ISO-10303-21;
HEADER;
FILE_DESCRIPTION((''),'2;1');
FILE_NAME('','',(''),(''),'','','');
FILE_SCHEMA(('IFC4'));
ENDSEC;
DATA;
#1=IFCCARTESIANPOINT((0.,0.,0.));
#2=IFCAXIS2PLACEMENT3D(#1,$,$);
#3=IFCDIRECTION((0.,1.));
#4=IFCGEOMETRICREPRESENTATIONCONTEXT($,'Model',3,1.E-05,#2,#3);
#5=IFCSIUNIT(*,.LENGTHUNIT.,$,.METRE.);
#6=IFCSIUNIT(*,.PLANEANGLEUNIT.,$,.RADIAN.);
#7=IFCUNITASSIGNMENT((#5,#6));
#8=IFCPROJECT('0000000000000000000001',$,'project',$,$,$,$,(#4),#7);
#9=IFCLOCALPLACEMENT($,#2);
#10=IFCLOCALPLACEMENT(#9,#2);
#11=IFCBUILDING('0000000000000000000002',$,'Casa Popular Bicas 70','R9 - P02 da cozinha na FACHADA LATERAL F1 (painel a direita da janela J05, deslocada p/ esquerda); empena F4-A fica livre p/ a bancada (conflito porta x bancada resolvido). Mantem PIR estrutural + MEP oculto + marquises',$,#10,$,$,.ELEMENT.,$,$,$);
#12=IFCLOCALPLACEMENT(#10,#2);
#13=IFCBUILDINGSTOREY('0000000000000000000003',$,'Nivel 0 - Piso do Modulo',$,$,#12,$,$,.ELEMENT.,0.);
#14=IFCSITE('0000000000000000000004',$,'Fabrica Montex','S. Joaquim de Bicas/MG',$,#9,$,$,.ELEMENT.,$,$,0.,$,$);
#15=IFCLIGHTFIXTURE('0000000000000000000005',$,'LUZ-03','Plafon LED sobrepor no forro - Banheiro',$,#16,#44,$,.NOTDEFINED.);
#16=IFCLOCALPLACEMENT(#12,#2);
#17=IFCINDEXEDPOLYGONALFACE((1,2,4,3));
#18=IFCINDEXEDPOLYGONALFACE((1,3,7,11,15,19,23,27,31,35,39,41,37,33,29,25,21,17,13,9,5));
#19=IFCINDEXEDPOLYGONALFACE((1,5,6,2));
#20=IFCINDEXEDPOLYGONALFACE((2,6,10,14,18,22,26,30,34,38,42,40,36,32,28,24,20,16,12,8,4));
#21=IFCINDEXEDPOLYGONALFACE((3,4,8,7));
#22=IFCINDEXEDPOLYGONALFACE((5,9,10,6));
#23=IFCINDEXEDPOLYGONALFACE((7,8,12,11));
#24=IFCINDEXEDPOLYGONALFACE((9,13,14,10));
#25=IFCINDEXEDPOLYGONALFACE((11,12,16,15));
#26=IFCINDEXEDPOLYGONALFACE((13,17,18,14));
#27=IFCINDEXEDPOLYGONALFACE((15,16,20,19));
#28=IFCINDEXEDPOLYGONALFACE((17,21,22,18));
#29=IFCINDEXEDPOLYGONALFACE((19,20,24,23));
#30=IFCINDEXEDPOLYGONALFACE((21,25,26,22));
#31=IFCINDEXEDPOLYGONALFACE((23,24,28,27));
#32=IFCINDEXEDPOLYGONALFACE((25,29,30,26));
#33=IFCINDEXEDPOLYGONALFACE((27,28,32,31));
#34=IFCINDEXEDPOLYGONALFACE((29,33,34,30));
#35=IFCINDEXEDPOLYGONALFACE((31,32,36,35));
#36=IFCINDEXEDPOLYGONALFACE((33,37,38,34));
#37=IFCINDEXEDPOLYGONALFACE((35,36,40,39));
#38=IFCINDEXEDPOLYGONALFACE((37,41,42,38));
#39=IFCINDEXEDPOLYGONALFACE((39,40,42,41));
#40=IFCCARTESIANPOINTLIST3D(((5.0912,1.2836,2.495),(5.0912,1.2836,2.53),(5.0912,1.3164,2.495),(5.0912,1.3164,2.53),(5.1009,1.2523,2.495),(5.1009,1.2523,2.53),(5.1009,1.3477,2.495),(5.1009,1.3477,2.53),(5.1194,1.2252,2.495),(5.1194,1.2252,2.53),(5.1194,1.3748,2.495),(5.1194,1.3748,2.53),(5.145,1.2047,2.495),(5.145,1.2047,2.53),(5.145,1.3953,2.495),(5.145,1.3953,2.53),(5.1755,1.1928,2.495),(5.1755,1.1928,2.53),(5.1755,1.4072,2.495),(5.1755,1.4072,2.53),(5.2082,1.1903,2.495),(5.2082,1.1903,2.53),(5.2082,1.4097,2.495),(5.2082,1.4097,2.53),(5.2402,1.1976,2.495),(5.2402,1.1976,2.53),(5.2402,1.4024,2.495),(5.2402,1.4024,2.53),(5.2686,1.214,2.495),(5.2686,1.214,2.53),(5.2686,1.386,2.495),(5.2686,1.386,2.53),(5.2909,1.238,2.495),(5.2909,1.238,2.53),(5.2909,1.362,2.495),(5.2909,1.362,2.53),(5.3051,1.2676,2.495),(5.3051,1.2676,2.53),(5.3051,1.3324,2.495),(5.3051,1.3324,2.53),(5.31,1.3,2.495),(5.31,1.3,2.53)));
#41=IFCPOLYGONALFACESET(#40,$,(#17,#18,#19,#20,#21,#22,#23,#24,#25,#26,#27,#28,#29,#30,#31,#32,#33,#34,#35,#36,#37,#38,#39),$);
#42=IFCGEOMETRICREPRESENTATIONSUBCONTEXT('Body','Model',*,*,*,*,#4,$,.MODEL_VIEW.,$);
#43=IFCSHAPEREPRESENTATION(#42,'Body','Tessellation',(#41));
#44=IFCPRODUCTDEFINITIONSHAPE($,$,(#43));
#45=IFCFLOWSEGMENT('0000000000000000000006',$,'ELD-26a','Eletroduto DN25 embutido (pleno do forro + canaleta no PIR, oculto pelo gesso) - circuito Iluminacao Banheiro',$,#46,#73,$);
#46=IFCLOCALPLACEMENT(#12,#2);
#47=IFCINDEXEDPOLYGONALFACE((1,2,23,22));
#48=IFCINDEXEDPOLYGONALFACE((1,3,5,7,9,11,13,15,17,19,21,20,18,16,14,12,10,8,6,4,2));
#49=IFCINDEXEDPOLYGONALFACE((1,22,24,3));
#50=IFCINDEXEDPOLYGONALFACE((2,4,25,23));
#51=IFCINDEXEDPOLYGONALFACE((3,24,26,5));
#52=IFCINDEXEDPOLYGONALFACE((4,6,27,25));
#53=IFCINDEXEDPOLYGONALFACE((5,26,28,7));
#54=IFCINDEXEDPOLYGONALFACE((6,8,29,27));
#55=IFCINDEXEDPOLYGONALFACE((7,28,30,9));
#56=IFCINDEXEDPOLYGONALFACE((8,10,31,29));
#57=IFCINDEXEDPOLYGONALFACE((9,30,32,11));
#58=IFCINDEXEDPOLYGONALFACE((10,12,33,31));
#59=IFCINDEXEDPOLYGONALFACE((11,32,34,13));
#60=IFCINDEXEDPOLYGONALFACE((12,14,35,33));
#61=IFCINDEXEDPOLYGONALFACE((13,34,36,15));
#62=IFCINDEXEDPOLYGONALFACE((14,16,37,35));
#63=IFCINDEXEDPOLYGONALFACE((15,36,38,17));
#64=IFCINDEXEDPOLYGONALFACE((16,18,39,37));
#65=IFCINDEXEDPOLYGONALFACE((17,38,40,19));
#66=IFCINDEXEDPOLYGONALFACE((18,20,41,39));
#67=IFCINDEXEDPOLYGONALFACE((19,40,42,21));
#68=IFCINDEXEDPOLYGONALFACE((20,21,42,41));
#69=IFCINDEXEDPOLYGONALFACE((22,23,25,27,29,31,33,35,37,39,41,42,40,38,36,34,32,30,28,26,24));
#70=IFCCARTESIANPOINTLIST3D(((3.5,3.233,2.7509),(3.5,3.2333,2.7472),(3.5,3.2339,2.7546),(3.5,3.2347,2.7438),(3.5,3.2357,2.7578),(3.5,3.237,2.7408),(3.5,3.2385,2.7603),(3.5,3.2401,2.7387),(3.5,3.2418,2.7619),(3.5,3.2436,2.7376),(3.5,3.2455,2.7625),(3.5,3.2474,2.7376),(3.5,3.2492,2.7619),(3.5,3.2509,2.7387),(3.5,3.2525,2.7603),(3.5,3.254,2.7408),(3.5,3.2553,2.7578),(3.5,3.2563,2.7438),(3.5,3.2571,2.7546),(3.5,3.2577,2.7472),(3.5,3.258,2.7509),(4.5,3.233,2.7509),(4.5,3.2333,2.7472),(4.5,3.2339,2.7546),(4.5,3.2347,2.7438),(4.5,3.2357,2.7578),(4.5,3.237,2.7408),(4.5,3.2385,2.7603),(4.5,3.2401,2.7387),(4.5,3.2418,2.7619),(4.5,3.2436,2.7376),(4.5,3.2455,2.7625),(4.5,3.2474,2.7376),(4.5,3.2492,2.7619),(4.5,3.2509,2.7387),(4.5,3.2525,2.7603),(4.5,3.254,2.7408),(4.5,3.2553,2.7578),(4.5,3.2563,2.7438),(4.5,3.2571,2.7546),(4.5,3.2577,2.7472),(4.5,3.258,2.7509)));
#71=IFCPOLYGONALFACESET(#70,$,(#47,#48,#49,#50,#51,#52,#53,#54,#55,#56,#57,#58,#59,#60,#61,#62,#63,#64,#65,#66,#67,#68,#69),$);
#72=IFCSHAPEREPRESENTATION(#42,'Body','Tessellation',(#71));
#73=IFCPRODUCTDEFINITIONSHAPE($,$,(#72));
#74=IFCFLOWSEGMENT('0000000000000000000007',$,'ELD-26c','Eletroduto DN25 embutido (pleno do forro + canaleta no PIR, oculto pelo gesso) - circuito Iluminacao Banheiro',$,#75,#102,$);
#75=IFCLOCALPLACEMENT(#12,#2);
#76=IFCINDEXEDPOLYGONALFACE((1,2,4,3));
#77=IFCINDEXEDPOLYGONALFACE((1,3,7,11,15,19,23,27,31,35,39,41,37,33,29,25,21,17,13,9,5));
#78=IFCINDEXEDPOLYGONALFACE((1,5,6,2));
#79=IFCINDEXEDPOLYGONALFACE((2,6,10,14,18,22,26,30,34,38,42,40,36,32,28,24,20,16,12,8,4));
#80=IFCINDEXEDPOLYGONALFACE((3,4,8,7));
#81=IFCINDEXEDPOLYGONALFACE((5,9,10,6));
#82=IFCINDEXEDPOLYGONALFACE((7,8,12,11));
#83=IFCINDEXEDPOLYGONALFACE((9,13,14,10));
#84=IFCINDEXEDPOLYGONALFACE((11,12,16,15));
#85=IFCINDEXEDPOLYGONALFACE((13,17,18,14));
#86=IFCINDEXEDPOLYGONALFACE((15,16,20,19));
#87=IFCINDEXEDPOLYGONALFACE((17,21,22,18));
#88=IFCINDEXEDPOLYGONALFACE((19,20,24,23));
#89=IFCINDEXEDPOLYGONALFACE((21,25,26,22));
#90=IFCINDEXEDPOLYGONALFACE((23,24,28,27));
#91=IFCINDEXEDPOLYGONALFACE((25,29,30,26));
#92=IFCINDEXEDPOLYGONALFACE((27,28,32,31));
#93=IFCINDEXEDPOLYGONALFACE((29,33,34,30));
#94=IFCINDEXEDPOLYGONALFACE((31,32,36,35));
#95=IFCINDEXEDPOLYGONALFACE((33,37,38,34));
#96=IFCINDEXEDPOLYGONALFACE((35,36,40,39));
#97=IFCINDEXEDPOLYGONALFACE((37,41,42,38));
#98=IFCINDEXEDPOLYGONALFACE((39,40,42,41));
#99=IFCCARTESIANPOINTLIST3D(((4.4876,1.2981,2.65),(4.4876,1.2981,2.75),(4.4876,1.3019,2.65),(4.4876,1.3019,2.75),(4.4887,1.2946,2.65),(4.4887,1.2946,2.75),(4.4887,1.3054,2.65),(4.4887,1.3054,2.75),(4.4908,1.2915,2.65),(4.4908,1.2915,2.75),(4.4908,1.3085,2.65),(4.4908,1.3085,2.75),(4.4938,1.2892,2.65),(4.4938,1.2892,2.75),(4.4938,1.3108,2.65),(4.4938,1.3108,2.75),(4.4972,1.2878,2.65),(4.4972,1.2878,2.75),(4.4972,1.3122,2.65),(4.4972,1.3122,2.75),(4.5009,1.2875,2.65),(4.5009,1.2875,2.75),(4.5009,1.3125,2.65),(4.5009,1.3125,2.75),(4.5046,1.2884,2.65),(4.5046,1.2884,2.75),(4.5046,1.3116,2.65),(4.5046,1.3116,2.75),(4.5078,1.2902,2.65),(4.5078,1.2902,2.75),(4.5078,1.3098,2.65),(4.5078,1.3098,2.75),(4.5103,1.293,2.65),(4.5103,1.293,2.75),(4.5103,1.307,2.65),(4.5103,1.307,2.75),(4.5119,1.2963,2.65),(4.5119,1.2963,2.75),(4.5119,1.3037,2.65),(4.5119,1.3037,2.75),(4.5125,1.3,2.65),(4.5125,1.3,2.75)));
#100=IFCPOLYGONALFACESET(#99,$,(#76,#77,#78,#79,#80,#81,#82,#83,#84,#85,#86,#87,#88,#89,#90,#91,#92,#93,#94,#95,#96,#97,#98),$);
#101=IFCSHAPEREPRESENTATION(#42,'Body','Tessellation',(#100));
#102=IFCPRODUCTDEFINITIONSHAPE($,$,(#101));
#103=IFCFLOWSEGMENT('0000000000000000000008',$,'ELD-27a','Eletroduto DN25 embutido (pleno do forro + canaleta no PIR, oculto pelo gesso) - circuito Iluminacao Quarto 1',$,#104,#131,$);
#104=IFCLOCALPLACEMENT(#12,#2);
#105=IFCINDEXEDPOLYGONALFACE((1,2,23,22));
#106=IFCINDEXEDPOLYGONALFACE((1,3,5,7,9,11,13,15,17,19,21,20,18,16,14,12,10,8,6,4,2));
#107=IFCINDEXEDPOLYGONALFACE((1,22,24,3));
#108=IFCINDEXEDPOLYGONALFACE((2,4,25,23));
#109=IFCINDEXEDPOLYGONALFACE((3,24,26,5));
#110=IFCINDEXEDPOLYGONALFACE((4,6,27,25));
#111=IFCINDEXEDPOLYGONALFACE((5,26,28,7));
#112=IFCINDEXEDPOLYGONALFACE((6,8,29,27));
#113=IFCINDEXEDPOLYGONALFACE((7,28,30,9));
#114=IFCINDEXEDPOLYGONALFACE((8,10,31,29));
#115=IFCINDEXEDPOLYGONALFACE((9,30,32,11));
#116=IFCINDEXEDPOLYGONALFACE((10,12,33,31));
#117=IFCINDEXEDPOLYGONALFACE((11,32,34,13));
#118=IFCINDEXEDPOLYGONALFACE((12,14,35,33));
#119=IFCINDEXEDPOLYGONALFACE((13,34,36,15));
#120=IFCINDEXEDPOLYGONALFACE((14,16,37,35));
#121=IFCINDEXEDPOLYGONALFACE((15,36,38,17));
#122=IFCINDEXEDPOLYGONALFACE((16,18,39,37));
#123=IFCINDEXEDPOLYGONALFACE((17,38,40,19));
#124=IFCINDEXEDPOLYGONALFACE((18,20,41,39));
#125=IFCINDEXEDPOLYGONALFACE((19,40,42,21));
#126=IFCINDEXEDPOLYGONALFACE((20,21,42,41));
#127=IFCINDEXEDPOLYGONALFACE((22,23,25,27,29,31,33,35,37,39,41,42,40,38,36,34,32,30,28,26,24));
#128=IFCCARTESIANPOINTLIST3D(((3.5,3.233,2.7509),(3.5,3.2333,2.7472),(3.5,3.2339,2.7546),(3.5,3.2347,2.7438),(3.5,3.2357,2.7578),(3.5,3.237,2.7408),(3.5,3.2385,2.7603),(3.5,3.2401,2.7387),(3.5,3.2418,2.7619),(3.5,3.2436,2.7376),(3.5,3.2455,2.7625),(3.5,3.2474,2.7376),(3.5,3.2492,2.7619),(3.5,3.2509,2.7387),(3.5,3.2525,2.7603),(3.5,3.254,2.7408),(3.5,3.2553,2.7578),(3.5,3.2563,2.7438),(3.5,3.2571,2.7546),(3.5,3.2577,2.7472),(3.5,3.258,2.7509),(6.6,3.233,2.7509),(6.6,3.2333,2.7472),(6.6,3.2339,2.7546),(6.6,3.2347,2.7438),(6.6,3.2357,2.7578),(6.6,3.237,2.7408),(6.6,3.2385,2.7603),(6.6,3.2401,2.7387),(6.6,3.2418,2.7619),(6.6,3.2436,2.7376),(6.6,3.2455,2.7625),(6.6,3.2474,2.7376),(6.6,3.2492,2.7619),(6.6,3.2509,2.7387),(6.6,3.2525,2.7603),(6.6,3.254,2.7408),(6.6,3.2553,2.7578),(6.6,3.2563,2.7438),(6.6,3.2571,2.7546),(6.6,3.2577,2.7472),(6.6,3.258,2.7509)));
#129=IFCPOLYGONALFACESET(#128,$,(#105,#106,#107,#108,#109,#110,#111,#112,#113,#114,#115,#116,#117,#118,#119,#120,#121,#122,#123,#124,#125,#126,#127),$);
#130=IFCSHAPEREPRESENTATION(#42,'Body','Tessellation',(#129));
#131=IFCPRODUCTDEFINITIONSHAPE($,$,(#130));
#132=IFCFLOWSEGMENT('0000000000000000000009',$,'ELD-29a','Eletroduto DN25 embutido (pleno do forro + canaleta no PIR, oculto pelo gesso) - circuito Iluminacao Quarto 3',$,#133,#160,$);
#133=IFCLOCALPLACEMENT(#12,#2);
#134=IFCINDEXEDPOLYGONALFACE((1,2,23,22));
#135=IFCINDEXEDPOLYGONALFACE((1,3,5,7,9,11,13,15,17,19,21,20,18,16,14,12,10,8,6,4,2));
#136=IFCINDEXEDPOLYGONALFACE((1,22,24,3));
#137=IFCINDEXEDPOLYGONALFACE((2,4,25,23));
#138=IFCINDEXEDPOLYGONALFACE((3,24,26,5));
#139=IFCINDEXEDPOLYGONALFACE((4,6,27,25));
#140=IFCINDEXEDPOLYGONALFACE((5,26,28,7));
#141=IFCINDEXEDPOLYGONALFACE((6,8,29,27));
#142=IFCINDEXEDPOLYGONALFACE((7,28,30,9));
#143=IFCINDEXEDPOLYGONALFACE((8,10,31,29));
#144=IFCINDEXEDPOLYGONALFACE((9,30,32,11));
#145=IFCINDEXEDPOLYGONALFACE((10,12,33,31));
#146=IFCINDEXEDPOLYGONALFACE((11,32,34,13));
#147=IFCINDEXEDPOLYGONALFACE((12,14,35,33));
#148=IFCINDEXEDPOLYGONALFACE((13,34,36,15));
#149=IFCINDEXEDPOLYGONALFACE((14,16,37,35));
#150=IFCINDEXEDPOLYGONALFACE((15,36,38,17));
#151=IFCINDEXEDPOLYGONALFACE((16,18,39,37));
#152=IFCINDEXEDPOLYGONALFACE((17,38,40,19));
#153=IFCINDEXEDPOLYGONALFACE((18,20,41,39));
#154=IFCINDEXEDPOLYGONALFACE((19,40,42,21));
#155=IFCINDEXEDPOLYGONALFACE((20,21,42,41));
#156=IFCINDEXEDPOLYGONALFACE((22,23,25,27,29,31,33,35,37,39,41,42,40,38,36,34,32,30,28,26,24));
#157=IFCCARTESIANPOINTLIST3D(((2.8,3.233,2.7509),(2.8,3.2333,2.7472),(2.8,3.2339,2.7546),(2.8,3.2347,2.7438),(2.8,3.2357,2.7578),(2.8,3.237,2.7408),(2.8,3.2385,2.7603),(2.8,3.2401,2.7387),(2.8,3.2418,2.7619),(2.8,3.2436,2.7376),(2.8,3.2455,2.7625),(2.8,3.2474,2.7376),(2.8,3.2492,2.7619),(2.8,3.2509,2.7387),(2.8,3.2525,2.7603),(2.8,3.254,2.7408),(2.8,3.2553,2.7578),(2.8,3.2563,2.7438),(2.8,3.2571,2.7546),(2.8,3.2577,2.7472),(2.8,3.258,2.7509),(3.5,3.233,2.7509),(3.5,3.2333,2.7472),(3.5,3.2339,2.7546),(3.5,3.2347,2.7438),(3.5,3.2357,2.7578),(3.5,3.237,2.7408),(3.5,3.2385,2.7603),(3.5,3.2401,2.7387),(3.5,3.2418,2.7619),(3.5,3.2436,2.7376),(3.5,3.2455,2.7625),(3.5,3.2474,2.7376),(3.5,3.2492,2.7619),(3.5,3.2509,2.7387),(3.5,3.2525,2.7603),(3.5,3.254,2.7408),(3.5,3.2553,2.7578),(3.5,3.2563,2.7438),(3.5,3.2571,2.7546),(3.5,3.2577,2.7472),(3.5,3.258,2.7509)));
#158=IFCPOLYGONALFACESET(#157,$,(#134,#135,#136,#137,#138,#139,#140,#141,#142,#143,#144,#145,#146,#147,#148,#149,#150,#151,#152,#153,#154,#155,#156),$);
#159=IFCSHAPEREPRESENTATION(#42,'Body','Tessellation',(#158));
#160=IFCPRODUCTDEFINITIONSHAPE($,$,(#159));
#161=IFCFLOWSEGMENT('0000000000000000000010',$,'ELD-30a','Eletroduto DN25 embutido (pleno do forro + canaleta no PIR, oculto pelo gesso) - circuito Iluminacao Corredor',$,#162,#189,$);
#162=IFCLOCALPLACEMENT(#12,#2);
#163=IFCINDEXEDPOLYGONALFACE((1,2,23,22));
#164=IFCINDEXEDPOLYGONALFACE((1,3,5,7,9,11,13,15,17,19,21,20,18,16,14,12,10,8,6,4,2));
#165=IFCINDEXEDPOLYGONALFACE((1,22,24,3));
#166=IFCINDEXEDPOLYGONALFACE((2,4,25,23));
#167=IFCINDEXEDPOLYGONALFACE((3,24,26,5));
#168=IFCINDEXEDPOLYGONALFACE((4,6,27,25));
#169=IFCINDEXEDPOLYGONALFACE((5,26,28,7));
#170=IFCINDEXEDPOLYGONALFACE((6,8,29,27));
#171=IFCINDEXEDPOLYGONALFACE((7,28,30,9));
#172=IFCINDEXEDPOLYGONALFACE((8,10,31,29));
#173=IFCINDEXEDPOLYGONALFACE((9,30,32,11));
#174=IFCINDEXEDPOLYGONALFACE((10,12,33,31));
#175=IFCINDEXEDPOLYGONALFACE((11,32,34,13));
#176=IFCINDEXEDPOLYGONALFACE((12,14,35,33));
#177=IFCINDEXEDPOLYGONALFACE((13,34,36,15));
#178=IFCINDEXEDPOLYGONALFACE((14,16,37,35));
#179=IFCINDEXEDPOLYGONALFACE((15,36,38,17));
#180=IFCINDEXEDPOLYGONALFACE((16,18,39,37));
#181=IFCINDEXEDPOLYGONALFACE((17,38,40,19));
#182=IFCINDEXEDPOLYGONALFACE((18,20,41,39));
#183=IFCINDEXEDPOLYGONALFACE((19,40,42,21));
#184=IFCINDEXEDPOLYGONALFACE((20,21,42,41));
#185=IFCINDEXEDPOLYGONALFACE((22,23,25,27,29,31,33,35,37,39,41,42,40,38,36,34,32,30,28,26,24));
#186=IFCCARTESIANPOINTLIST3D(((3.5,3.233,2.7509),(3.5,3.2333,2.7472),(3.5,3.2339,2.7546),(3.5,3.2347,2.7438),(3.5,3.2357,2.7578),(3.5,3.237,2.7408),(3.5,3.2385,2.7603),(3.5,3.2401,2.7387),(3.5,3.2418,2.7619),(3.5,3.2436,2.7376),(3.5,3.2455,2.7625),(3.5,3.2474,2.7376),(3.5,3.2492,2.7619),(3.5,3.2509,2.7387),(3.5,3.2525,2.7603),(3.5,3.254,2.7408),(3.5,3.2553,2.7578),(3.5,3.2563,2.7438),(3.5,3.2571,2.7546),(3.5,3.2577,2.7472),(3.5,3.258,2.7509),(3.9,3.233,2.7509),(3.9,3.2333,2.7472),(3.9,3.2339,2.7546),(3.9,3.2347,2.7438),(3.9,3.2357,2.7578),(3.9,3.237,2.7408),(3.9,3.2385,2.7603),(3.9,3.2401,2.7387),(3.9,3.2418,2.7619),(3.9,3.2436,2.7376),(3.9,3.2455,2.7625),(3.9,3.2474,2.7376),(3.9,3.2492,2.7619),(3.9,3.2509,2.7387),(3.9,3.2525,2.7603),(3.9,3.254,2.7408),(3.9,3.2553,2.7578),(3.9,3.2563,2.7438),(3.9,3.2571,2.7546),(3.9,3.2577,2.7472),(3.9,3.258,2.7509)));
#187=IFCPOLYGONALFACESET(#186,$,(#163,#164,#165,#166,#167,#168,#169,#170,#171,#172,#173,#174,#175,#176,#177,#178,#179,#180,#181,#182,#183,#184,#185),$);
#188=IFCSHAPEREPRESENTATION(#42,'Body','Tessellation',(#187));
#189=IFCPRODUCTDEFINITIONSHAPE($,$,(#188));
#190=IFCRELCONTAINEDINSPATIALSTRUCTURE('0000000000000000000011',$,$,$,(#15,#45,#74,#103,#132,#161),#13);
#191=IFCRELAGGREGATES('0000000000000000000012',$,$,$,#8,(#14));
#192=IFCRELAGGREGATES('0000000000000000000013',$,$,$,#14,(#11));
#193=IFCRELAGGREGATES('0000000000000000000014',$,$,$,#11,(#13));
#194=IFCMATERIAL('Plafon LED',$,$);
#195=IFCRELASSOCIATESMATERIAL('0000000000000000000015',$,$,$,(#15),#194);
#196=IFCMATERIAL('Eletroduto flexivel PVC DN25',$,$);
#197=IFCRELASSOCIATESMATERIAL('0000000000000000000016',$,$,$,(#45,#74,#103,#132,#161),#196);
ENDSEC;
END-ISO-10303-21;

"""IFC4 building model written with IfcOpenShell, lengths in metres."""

from ifc_helpers import new_model, si_unit, direction, frame, origin, origin_2d, place, context, subcontext, project, spatial, circle, extrude, material, element, save


model = new_model("IFC4")

# Units and contexts
model_context = context("Model", 3, precision=1e-05, world=origin(), true_north=direction((0.0, 1.0)))
body_context = subcontext(model_context, "Body", "Model", "MODEL_VIEW")
ifc_project = project(units=[si_unit("LENGTHUNIT", "METRE"), si_unit("PLANEANGLEUNIT", "RADIAN")], contexts=[model_context])

# Site, building, storey
site_placement = place(None, origin())
site = spatial("IfcSite", under=ifc_project, at=site_placement, Name="Fabrica Montex", Description="S. Joaquim de Bicas/MG", CompositionType="ELEMENT", RefElevation=0.0)
building_placement = place(site_placement, origin())
building = spatial("IfcBuilding", under=site, at=building_placement, Name="Casa Popular Bicas 70", Description="R9 - P02 da cozinha na FACHADA LATERAL F1 (painel a direita da janela J05, deslocada p/ esquerda); empena F4-A fica livre p/ a bancada (conflito porta x bancada resolvido). Mantem PIR estrutural + MEP oculto + marquises", CompositionType="ELEMENT")
storey_placement = place(building_placement, origin())
storey = spatial("IfcBuildingStorey", under=building, at=storey_placement, Name="Nivel 0 - Piso do Modulo", CompositionType="ELEMENT", Elevation=0.0)

# Shared definitions
ifc_material_1 = material(Name="Eletroduto flexivel PVC DN25")

# Light fixture
ifc_material_2 = material(Name="Plafon LED")
light_fixture_placement = place(storey_placement, frame((5.2, 1.3, 2.495)))
element("IfcLightFixture", 1, at=light_fixture_placement, inside=storey, material=ifc_material_2, Name="LUZ-03", Description="Plafon LED sobrepor no forro - Banheiro", PredefinedType="NOTDEFINED", context=body_context, shape_type="SweptSolid", body=[
    extrude(circle(Radius=0.11, at=origin_2d()), origin(), (0.0, 0.0, 1.0), 0.035),
])

# Flow segments
flow_segment_1_placement = place(storey_placement, frame((3.5, 3.2455, 2.75), z_axis=(1.0, 0.0, 0.0), x_axis=(0.0, 0.0, 1.0)))
element("IfcFlowSegment", 2, at=flow_segment_1_placement, inside=storey, material=ifc_material_1, Name="ELD-26a", Description="Eletroduto DN25 embutido (pleno do forro + canaleta no PIR, oculto pelo gesso) - circuito Iluminacao Banheiro", context=body_context, shape_type="SweptSolid", body=[
    extrude(circle(Radius=0.0125, at=origin_2d()), origin(), (0.0, 0.0, 1.0), 1.0),
])
flow_segment_2_placement = place(storey_placement, frame((4.5, 1.3, 2.75), z_axis=(0.0, 0.0, -1.0), x_axis=(1.0, 0.0, 0.0)))
element("IfcFlowSegment", 3, at=flow_segment_2_placement, inside=storey, material=ifc_material_1, Name="ELD-26c", Description="Eletroduto DN25 embutido (pleno do forro + canaleta no PIR, oculto pelo gesso) - circuito Iluminacao Banheiro", context=body_context, shape_type="SweptSolid", body=[
    extrude(circle(Radius=0.0125, at=origin_2d()), origin(), (0.0, 0.0, 1.0), 0.1),
])
for number, where, z_axis, x_axis, name in (
    (4, (3.5, 3.2455, 2.75), (1.0, 0.0, 0.0), (0.0, 0.0, 1.0), "ELD-27a"),
):
    element("IfcFlowSegment", number, at=place(storey_placement, frame(where, z_axis=z_axis, x_axis=x_axis)), inside=storey, material=ifc_material_1, Name=name, Description="Eletroduto DN25 embutido (pleno do forro + canaleta no PIR, oculto pelo gesso) - circuito Iluminacao Quarto 1", context=body_context, shape_type="SweptSolid", body=[
        extrude(circle(Radius=0.0125, at=origin_2d()), origin(), (0.0, 0.0, 1.0), 3.1),
    ])
flow_segment_3_placement = place(storey_placement, frame((3.5, 3.2455, 2.75), z_axis=(-1.0, 0.0, 0.0), x_axis=(0.0, 0.0, 1.0)))
element("IfcFlowSegment", 5, at=flow_segment_3_placement, inside=storey, material=ifc_material_1, Name="ELD-29a", Description="Eletroduto DN25 embutido (pleno do forro + canaleta no PIR, oculto pelo gesso) - circuito Iluminacao Quarto 3", context=body_context, shape_type="SweptSolid", body=[
    extrude(circle(Radius=0.0125, at=origin_2d()), origin(), (0.0, 0.0, 1.0), 0.7),
])
flow_segment_4_placement = place(storey_placement, frame((3.5, 3.2455, 2.75), z_axis=(1.0, 0.0, 0.0), x_axis=(0.0, 0.0, 1.0)))
element("IfcFlowSegment", 6, at=flow_segment_4_placement, inside=storey, material=ifc_material_1, Name="ELD-30a", Description="Eletroduto DN25 embutido (pleno do forro + canaleta no PIR, oculto pelo gesso) - circuito Iluminacao Corredor", context=body_context, shape_type="SweptSolid", body=[
    extrude(circle(Radius=0.0125, at=origin_2d()), origin(), (0.0, 0.0, 1.0), 0.4),
])

save(model, "model.ifc")
